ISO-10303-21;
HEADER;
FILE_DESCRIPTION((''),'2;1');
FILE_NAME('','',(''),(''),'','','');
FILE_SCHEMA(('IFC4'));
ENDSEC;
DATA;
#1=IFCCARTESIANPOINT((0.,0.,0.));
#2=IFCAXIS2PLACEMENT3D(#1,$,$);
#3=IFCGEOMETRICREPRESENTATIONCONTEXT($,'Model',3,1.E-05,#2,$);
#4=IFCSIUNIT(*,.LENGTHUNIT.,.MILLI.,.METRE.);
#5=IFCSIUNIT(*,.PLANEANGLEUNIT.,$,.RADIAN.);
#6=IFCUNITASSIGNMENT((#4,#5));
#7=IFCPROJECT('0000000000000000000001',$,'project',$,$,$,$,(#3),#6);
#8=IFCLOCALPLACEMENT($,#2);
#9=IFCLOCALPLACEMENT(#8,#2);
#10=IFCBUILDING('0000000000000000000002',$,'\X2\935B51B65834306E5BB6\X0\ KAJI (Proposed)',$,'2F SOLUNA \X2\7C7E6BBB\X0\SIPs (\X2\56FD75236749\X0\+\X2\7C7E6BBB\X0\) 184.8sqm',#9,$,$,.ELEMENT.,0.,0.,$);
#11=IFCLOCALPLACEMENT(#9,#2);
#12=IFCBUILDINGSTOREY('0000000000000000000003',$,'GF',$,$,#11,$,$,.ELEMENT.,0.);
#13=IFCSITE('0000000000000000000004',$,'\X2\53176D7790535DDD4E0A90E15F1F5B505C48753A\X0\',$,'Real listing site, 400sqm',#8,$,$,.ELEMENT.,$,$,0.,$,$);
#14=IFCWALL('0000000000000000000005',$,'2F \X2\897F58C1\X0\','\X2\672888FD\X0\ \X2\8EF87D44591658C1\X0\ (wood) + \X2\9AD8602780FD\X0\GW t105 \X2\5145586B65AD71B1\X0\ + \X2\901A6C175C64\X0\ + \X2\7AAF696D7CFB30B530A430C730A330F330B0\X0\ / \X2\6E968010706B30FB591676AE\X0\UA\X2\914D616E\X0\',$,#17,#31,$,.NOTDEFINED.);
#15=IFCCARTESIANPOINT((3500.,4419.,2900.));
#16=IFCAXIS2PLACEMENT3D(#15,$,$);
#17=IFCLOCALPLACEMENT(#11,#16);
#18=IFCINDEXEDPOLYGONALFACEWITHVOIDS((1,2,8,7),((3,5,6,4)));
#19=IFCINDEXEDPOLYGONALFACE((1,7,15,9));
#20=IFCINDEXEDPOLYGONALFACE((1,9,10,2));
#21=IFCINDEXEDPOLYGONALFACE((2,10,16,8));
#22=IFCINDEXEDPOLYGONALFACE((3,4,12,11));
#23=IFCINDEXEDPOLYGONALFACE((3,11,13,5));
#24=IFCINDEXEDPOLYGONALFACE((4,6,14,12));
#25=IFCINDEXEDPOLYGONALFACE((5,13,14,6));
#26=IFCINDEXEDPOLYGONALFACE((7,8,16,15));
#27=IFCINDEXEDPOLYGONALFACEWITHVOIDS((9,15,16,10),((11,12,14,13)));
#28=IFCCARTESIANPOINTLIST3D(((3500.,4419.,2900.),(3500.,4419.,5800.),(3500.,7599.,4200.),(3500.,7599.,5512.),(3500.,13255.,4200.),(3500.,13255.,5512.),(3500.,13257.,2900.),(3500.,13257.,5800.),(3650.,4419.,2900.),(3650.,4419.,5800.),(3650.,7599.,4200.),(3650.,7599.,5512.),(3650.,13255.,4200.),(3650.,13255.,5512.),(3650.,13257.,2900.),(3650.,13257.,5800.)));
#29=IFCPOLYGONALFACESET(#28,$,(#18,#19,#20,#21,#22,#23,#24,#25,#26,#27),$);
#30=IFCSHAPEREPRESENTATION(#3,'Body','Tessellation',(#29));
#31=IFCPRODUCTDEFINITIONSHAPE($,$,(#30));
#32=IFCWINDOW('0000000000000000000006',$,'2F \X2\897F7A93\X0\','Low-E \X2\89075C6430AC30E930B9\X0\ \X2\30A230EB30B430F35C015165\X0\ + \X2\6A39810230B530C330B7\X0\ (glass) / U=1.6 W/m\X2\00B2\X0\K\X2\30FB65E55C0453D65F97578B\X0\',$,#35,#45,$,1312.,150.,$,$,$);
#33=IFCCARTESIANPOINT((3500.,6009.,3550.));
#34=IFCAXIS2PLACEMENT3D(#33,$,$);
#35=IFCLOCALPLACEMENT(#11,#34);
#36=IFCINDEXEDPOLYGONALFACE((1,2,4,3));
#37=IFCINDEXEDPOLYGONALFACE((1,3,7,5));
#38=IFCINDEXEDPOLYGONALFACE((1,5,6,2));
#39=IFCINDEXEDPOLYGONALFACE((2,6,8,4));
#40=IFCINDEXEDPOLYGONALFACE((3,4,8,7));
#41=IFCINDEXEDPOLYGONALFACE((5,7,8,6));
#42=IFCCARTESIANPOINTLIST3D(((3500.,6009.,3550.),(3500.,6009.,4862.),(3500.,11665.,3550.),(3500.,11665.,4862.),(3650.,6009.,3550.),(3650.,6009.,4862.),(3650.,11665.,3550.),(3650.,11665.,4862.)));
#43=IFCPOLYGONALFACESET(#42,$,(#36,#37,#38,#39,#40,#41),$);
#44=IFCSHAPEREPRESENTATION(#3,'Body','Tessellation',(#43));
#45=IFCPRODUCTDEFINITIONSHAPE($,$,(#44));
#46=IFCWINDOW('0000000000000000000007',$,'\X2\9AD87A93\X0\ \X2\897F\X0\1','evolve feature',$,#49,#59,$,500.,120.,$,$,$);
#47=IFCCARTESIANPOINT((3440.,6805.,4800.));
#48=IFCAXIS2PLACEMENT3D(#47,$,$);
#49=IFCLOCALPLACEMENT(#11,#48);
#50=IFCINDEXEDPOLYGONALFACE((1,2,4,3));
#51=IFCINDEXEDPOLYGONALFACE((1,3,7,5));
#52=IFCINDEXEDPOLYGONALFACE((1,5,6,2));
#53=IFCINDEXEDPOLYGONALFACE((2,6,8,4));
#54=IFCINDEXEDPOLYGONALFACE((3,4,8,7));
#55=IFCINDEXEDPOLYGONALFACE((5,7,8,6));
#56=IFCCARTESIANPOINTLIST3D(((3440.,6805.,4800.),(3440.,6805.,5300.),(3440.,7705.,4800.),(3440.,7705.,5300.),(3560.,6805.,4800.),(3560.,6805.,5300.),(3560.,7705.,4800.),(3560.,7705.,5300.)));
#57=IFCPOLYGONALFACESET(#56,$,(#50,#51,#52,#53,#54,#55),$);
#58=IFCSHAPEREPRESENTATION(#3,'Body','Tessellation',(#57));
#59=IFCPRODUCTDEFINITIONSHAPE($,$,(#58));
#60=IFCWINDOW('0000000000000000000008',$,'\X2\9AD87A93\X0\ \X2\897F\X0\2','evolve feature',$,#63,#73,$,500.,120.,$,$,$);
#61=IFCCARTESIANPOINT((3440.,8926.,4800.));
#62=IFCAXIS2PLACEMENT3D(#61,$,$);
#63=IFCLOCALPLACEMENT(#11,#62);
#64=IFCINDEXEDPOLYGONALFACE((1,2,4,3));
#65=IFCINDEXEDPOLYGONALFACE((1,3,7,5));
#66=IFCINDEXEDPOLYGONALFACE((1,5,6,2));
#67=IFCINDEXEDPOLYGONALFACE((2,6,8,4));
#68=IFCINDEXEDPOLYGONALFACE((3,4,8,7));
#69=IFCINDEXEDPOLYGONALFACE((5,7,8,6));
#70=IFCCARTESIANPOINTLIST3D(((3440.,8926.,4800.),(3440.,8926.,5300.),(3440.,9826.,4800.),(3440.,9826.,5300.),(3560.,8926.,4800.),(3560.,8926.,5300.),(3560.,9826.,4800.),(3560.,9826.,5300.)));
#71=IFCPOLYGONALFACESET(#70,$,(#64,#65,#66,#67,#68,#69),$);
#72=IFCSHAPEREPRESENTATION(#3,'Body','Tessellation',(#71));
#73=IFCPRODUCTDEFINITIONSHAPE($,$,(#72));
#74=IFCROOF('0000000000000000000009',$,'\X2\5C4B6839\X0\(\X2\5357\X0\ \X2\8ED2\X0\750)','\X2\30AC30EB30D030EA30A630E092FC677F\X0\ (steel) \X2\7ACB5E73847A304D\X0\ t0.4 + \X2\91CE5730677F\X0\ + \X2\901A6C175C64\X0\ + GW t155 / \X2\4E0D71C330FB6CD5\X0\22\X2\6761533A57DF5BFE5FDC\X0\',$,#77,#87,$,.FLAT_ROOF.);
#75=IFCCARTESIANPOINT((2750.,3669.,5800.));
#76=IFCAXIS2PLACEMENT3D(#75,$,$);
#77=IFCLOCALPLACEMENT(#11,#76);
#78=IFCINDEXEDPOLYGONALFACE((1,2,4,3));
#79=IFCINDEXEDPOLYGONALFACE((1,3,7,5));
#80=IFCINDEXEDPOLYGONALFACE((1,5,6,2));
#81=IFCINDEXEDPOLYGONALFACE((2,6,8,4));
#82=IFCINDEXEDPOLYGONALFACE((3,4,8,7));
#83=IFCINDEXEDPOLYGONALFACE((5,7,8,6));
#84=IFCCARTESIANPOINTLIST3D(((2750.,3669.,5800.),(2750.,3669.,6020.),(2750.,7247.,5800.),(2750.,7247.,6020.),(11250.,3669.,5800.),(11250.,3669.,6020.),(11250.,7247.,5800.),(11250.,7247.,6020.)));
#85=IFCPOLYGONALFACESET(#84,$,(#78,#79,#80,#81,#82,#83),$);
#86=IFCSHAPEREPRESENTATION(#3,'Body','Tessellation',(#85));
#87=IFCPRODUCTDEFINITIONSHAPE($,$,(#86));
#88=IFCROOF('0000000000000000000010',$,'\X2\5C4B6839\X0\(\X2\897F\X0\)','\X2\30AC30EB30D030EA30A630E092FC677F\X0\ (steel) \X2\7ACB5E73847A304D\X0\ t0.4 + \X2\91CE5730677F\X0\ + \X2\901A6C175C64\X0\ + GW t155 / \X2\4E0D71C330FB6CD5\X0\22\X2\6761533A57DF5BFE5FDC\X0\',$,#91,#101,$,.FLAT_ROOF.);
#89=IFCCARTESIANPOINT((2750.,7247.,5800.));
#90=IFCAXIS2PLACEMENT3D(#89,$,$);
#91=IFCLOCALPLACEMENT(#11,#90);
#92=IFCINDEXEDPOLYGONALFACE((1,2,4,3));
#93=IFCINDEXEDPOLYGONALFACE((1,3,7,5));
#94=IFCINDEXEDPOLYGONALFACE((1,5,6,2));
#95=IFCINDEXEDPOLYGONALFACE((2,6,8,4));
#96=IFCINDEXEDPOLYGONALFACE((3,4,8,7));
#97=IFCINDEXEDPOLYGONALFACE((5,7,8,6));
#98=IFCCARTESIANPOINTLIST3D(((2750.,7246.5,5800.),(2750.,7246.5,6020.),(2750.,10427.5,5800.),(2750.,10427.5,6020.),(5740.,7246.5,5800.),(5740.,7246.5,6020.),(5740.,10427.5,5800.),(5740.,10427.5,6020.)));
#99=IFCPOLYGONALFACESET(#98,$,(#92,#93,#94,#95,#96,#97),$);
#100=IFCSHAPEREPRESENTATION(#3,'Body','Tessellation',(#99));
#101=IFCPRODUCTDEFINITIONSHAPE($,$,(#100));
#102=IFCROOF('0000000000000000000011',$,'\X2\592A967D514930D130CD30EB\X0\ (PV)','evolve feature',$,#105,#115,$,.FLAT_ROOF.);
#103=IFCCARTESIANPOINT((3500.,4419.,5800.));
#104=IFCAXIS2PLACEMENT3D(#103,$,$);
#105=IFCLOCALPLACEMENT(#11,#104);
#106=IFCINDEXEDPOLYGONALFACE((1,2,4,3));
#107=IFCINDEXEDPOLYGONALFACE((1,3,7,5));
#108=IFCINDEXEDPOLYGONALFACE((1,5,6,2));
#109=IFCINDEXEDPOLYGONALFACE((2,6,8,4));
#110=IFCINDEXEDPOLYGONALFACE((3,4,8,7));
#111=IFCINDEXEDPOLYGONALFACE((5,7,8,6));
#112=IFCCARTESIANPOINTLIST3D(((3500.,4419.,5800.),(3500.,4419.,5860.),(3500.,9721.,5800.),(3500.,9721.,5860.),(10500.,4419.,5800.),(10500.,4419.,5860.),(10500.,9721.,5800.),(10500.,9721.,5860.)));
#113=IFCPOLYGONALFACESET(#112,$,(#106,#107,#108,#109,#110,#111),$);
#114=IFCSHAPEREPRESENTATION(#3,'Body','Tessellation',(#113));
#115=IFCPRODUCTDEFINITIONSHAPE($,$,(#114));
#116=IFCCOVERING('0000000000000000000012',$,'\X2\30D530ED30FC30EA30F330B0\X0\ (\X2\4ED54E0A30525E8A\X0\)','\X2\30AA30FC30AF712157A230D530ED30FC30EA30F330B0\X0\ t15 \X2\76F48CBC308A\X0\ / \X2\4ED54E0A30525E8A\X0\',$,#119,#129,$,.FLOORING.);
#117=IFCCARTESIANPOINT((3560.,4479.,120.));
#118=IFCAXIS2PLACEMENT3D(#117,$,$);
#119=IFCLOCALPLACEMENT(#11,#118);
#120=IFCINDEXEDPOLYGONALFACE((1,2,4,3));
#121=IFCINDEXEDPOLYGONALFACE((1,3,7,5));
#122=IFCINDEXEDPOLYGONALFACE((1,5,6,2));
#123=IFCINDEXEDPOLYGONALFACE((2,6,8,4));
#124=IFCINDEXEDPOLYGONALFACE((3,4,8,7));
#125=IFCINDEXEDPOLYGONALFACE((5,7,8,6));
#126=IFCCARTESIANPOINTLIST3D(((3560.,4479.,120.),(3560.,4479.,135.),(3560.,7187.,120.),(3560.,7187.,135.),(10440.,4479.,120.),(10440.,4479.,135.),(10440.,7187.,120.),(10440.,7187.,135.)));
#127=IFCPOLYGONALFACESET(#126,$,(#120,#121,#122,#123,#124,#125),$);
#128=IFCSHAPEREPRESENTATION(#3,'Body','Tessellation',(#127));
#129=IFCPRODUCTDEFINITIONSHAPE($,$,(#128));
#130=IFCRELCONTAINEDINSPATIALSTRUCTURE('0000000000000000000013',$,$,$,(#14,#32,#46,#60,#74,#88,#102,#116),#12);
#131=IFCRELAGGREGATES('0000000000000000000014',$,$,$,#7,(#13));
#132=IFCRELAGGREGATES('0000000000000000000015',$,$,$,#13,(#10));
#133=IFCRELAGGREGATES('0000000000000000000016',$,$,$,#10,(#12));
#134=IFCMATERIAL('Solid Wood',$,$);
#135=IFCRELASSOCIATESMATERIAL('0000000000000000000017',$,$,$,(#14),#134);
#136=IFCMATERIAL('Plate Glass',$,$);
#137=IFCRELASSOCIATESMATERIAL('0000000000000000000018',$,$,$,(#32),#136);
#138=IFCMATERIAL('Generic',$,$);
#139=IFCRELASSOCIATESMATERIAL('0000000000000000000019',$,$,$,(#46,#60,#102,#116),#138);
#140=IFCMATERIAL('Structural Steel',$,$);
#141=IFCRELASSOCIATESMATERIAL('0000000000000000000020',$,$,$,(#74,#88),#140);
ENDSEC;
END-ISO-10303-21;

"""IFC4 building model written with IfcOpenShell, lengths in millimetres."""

from ifc_helpers import new_model, si_unit, frame, frame_2d, origin, place, context, project, spatial, rectangle, extrude, material, element, fill, save


model = new_model("IFC4")

# Units and contexts
model_context = context("Model", 3, precision=1e-05, world=origin())
ifc_project = project(units=[si_unit("LENGTHUNIT", "METRE", prefix="MILLI"), si_unit("PLANEANGLEUNIT", "RADIAN")], contexts=[model_context])

# Site, building, storey
site_placement = place(None, origin())
site = spatial("IfcSite", under=ifc_project, at=site_placement, Name="北海道川上郡弟子屈町", ObjectType="Real listing site, 400sqm", CompositionType="ELEMENT", RefElevation=0.0)
building_placement = place(site_placement, origin())
building = spatial("IfcBuilding", under=site, at=building_placement, Name="鍛冶場の家 KAJI (Proposed)", ObjectType="2F SOLUNA 籾殻SIPs (国産杉+籾殻) 184.8sqm", CompositionType="ELEMENT", ElevationOfRefHeight=0.0, ElevationOfTerrain=0.0)
storey_placement = place(building_placement, origin())
storey = spatial("IfcBuildingStorey", under=building, at=storey_placement, Name="GF", CompositionType="ELEMENT", Elevation=0.0)

# Shared definitions
ifc_material_1 = material(Name="Solid Wood")
ifc_material_2 = material(Name="Generic")

# Shared definitions
ifc_material_3 = material(Name="Plate Glass")

# Wall, openings, windows
wall_1_placement = place(storey_placement, frame((3500.0, 4419.0, 2900.0)))
wall_1 = element("IfcWall", 1, at=wall_1_placement, inside=storey, material=ifc_material_1, Name="2F 西壁", Description="木製 軸組外壁 (wood) + 高性能GW t105 充填断熱 + 通気層 + 窯業系サイディング / 準耐火・外皮UA配慮", PredefinedType="NOTDEFINED", context=model_context, shape_type="SweptSolid", body=[
    extrude(rectangle(XDim=150.0, YDim=8838.0, at=frame_2d((75.0, 4419.0))), frame((3500.0, 4419.0, 2900.0)), (0.0, 0.0, 1.0), 2900.0),
])
opening_1_placement = place(storey_placement, frame((3500.0, 6009.0, 3550.0)))
opening_1 = element("IfcOpeningElement", 2, at=opening_1_placement, cuts=wall_1, PredefinedType="NOTDEFINED", context=model_context, shape_type="SweptSolid", body=[
    extrude(rectangle(XDim=150.0, YDim=5656.0, at=frame_2d((75.0, 2828.0))), frame((3500.0, 6009.0, 3550.0)), (0.0, 0.0, 1.0), 1312.0),
])
opening_2_placement = place(storey_placement, frame((3440.0, 6805.0, 4800.0)))
opening_2 = element("IfcOpeningElement", 3, at=opening_2_placement, cuts=wall_1, PredefinedType="NOTDEFINED", context=model_context, shape_type="SweptSolid", body=[
    extrude(rectangle(XDim=120.0, YDim=900.0, at=frame_2d((60.0, 450.0))), frame((3440.0, 6805.0, 4800.0)), (0.0, 0.0, 1.0), 500.0),
])
opening_3_placement = place(storey_placement, frame((3440.0, 8926.0, 4800.0)))
opening_3 = element("IfcOpeningElement", 4, at=opening_3_placement, cuts=wall_1, PredefinedType="NOTDEFINED", context=model_context, shape_type="SweptSolid", body=[
    extrude(rectangle(XDim=120.0, YDim=900.0, at=frame_2d((60.0, 450.0))), frame((3440.0, 8926.0, 4800.0)), (0.0, 0.0, 1.0), 500.0),
])
window_1_placement = place(storey_placement, frame((3500.0, 6009.0, 3550.0)))
window_1 = element("IfcWindow", 5, at=window_1_placement, inside=storey, material=ifc_material_3, Name="2F 西窓", Description="Low-E 複層ガラス アルゴン封入 + 樹脂サッシ (glass) / U=1.6 W/m²K・日射取得型", OverallHeight=1312.0, OverallWidth=150.0, context=model_context, shape_type="SweptSolid", body=[
    extrude(rectangle(XDim=150.0, YDim=5656.0, at=frame_2d((75.0, 2828.0))), frame((3500.0, 6009.0, 3550.0)), (0.0, 0.0, 1.0), 1312.0),
])
fill(opening_1, window_1)
window_2_placement = place(storey_placement, frame((3440.0, 6805.0, 4800.0)))
window_2 = element("IfcWindow", 6, at=window_2_placement, inside=storey, material=ifc_material_2, Name="高窓 西1", Description="evolve feature", OverallHeight=500.0, OverallWidth=120.0, context=model_context, shape_type="SweptSolid", body=[
    extrude(rectangle(XDim=120.0, YDim=900.0, at=frame_2d((60.0, 450.0))), frame((3440.0, 6805.0, 4800.0)), (0.0, 0.0, 1.0), 500.0),
])
fill(opening_2, window_2)
window_3_placement = place(storey_placement, frame((3440.0, 8926.0, 4800.0)))
window_3 = element("IfcWindow", 7, at=window_3_placement, inside=storey, material=ifc_material_2, Name="高窓 西2", Description="evolve feature", OverallHeight=500.0, OverallWidth=120.0, context=model_context, shape_type="SweptSolid", body=[
    extrude(rectangle(XDim=120.0, YDim=900.0, at=frame_2d((60.0, 450.0))), frame((3440.0, 8926.0, 4800.0)), (0.0, 0.0, 1.0), 500.0),
])
fill(opening_3, window_3)

# Roofs
ifc_material_4 = material(Name="Structural Steel")
roof_1_placement = place(storey_placement, frame((2750.0, 3669.0, 5800.0)))
element("IfcRoof", 8, at=roof_1_placement, inside=storey, material=ifc_material_4, Name="屋根(南 軒750)", Description="ガルバリウム鋼板 (steel) 立平葺き t0.4 + 野地板 + 通気層 + GW t155 / 不燃・法22条区域対応", PredefinedType="FLAT_ROOF", context=model_context, shape_type="SweptSolid", body=[
    extrude(rectangle(XDim=8500.0, YDim=3578.0, at=frame_2d((4250.0, 1789.0))), frame((2750.0, 3669.0, 5800.0)), (0.0, 0.0, 1.0), 220.0),
])
roof_2_placement = place(storey_placement, frame((2750.0, 7247.0, 5800.0)))
element("IfcRoof", 9, at=roof_2_placement, inside=storey, material=ifc_material_4, Name="屋根(西)", Description="ガルバリウム鋼板 (steel) 立平葺き t0.4 + 野地板 + 通気層 + GW t155 / 不燃・法22条区域対応", PredefinedType="FLAT_ROOF", context=model_context, shape_type="SweptSolid", body=[
    extrude(rectangle(XDim=2990.0, YDim=3181.0, at=frame_2d((1495.0, 1590.0))), frame((2750.0, 7247.0, 5800.0)), (0.0, 0.0, 1.0), 220.0),
])
roof_3_placement = place(storey_placement, frame((3500.0, 4419.0, 5800.0)))
element("IfcRoof", 10, at=roof_3_placement, inside=storey, material=ifc_material_2, Name="太陽光パネル (PV)", Description="evolve feature", PredefinedType="FLAT_ROOF", context=model_context, shape_type="SweptSolid", body=[
    extrude(rectangle(XDim=7000.0, YDim=5302.0, at=frame_2d((3500.0, 2651.0))), frame((3500.0, 4419.0, 5800.0)), (0.0, 0.0, 1.0), 60.0),
])

# Covering
covering_placement = place(storey_placement, frame((3560.0, 4479.0, 120.0)))
element("IfcCovering", 11, at=covering_placement, inside=storey, material=ifc_material_2, Name="フローリング (仕上げ床)", Description="オーク無垢フローリング t15 直貼り / 仕上げ床", PredefinedType="FLOORING", context=model_context, shape_type="SweptSolid", body=[
    extrude(rectangle(XDim=6880.0, YDim=2708.0, at=frame_2d((3440.0, 1354.0))), frame((3560.0, 4479.0, 120.0)), (0.0, 0.0, 1.0), 15.0),
])

save(model, "model.ifc")
